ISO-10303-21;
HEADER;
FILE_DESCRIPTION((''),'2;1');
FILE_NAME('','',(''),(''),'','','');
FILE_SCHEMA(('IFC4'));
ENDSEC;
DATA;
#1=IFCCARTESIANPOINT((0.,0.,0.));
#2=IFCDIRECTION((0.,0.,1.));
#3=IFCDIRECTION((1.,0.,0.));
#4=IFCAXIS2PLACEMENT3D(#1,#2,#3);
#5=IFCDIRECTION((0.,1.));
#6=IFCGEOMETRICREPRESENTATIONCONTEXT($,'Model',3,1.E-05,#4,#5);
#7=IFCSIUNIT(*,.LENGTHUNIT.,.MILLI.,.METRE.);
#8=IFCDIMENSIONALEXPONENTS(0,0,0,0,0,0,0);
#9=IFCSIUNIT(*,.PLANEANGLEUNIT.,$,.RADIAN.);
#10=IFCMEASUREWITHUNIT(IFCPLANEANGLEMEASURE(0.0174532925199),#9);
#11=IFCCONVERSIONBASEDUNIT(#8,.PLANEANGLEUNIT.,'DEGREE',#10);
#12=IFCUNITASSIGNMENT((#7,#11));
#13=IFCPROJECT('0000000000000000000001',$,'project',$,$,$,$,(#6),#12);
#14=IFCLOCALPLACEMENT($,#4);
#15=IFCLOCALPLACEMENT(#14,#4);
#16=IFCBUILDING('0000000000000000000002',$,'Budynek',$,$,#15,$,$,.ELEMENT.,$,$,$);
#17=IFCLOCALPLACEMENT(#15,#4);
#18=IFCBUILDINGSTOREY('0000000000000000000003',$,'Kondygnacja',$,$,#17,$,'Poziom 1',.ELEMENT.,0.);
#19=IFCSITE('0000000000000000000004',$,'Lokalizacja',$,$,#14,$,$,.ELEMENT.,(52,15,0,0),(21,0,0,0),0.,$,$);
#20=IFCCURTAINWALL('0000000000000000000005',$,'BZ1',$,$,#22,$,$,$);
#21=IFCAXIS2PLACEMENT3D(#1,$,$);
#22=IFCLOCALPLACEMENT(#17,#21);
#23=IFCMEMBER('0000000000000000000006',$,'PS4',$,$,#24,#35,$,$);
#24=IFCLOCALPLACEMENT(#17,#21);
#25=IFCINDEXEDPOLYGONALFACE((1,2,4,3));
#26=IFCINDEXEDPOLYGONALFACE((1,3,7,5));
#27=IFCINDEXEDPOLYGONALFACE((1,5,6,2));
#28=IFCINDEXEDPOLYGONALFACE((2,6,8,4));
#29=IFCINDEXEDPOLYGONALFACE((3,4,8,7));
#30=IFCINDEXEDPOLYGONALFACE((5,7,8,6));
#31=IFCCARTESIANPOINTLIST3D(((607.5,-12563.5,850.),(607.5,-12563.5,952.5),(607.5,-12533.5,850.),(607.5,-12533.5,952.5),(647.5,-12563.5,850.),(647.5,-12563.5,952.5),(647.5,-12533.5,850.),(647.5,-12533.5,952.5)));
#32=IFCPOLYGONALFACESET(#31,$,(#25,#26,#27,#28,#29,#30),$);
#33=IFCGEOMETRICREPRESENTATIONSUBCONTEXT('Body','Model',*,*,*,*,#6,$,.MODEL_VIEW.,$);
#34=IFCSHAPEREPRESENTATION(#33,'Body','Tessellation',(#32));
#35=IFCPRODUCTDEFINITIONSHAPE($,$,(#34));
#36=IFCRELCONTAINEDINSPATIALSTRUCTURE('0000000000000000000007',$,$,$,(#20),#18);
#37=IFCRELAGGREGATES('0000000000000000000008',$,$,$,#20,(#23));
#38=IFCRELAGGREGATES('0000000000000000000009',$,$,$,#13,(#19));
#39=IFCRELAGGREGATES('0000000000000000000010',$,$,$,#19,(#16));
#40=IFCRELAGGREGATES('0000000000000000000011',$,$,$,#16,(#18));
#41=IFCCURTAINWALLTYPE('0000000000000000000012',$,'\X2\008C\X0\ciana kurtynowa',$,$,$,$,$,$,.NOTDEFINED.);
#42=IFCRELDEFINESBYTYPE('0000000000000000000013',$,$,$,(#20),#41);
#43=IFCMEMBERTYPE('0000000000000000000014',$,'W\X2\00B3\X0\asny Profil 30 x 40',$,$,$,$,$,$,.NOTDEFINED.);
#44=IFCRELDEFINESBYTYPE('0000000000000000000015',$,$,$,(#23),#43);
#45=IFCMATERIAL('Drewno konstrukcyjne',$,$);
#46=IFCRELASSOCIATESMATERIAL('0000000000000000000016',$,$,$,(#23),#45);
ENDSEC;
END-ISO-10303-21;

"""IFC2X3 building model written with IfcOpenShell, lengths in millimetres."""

from ifc_helpers import new_model, entity, si_unit, converted_unit, direction, frame, origin_with_axes, place, context, subcontext, project, spatial, polyline, outline, extrude, material, type_object, element, aggregate, save


model = new_model("IFC2X3")

# Units and contexts
model_context = context("Model", 3, precision=1e-05, world=origin_with_axes(), true_north=direction((0.0, 1.0)))
body_context = subcontext(model_context, "Body", "Model", "MODEL_VIEW")
ifc_project = project(units=[si_unit("LENGTHUNIT", "METRE", prefix="MILLI"), converted_unit("PLANEANGLEUNIT", "DEGREE", entity("IfcPlaneAngleMeasure", 0.0174532925199), si_unit("PLANEANGLEUNIT", "RADIAN"), dimensions=[0, 0, 0, 0, 0, 0, 0])], contexts=[model_context])

# Site, building, storey
site_placement = place(None, origin_with_axes())
site = spatial("IfcSite", under=ifc_project, at=site_placement, Name="Lokalizacja", CompositionType="ELEMENT", RefLatitude=(52, 15, 0, 0), RefLongitude=(21, 0, 0, 0), RefElevation=0.0)
building_placement = place(site_placement, origin_with_axes())
building = spatial("IfcBuilding", under=site, at=building_placement, Name="Budynek", CompositionType="ELEMENT")
storey_placement = place(building_placement, origin_with_axes())
storey = spatial("IfcBuildingStorey", under=building, at=storey_placement, Name="Kondygnacja", LongName="Poziom 1", CompositionType="ELEMENT", Elevation=0.0)

# Curtain wall, member
curtain_wall_type = type_object("IfcCurtainWallType", Name="\u008cciana kurtynowa", PredefinedType="NOTDEFINED")
curtain_wall_placement = place(storey_placement, frame((647.5, -18408.5, 0.0), z_axis=(0.0, 0.0, 1.0), x_axis=(1.0, 0.0, 0.0)))
curtain_wall = element("IfcCurtainWall", 1, at=curtain_wall_placement, inside=storey, type_object=curtain_wall_type, Name="BZ1")
ifc_material_1 = material(Name="Drewno konstrukcyjne")
member_type_1 = type_object("IfcMemberType", Name="W³asny Profil 30 x 40", PredefinedType="NOTDEFINED")
member_1_placement = place(curtain_wall_placement, frame((0.0, 5860.0, 850.0), z_axis=(0.0, 0.0, 1.0), x_axis=(0.0, -1.0, 0.0)))
member_1 = element("IfcMember", 2, at=member_1_placement, type_object=member_type_1, material=ifc_material_1, Name="PS4", context=body_context, shape_type="SweptSolid", body=[
    extrude(outline(polyline([(-40.0, -15.0), (0.0, -15.0), (0.0, 15.0), (-40.0, 15.0), (-40.0, -15.0)])), frame((0.0, 0.0, 0.0), z_axis=(0.0, 0.0, 1.0), x_axis=(0.0, 1.0, 0.0)), (0.0, 0.0, 1.0), 102.5),
])
aggregate(curtain_wall, [member_1])

save(model, "model.ifc")
